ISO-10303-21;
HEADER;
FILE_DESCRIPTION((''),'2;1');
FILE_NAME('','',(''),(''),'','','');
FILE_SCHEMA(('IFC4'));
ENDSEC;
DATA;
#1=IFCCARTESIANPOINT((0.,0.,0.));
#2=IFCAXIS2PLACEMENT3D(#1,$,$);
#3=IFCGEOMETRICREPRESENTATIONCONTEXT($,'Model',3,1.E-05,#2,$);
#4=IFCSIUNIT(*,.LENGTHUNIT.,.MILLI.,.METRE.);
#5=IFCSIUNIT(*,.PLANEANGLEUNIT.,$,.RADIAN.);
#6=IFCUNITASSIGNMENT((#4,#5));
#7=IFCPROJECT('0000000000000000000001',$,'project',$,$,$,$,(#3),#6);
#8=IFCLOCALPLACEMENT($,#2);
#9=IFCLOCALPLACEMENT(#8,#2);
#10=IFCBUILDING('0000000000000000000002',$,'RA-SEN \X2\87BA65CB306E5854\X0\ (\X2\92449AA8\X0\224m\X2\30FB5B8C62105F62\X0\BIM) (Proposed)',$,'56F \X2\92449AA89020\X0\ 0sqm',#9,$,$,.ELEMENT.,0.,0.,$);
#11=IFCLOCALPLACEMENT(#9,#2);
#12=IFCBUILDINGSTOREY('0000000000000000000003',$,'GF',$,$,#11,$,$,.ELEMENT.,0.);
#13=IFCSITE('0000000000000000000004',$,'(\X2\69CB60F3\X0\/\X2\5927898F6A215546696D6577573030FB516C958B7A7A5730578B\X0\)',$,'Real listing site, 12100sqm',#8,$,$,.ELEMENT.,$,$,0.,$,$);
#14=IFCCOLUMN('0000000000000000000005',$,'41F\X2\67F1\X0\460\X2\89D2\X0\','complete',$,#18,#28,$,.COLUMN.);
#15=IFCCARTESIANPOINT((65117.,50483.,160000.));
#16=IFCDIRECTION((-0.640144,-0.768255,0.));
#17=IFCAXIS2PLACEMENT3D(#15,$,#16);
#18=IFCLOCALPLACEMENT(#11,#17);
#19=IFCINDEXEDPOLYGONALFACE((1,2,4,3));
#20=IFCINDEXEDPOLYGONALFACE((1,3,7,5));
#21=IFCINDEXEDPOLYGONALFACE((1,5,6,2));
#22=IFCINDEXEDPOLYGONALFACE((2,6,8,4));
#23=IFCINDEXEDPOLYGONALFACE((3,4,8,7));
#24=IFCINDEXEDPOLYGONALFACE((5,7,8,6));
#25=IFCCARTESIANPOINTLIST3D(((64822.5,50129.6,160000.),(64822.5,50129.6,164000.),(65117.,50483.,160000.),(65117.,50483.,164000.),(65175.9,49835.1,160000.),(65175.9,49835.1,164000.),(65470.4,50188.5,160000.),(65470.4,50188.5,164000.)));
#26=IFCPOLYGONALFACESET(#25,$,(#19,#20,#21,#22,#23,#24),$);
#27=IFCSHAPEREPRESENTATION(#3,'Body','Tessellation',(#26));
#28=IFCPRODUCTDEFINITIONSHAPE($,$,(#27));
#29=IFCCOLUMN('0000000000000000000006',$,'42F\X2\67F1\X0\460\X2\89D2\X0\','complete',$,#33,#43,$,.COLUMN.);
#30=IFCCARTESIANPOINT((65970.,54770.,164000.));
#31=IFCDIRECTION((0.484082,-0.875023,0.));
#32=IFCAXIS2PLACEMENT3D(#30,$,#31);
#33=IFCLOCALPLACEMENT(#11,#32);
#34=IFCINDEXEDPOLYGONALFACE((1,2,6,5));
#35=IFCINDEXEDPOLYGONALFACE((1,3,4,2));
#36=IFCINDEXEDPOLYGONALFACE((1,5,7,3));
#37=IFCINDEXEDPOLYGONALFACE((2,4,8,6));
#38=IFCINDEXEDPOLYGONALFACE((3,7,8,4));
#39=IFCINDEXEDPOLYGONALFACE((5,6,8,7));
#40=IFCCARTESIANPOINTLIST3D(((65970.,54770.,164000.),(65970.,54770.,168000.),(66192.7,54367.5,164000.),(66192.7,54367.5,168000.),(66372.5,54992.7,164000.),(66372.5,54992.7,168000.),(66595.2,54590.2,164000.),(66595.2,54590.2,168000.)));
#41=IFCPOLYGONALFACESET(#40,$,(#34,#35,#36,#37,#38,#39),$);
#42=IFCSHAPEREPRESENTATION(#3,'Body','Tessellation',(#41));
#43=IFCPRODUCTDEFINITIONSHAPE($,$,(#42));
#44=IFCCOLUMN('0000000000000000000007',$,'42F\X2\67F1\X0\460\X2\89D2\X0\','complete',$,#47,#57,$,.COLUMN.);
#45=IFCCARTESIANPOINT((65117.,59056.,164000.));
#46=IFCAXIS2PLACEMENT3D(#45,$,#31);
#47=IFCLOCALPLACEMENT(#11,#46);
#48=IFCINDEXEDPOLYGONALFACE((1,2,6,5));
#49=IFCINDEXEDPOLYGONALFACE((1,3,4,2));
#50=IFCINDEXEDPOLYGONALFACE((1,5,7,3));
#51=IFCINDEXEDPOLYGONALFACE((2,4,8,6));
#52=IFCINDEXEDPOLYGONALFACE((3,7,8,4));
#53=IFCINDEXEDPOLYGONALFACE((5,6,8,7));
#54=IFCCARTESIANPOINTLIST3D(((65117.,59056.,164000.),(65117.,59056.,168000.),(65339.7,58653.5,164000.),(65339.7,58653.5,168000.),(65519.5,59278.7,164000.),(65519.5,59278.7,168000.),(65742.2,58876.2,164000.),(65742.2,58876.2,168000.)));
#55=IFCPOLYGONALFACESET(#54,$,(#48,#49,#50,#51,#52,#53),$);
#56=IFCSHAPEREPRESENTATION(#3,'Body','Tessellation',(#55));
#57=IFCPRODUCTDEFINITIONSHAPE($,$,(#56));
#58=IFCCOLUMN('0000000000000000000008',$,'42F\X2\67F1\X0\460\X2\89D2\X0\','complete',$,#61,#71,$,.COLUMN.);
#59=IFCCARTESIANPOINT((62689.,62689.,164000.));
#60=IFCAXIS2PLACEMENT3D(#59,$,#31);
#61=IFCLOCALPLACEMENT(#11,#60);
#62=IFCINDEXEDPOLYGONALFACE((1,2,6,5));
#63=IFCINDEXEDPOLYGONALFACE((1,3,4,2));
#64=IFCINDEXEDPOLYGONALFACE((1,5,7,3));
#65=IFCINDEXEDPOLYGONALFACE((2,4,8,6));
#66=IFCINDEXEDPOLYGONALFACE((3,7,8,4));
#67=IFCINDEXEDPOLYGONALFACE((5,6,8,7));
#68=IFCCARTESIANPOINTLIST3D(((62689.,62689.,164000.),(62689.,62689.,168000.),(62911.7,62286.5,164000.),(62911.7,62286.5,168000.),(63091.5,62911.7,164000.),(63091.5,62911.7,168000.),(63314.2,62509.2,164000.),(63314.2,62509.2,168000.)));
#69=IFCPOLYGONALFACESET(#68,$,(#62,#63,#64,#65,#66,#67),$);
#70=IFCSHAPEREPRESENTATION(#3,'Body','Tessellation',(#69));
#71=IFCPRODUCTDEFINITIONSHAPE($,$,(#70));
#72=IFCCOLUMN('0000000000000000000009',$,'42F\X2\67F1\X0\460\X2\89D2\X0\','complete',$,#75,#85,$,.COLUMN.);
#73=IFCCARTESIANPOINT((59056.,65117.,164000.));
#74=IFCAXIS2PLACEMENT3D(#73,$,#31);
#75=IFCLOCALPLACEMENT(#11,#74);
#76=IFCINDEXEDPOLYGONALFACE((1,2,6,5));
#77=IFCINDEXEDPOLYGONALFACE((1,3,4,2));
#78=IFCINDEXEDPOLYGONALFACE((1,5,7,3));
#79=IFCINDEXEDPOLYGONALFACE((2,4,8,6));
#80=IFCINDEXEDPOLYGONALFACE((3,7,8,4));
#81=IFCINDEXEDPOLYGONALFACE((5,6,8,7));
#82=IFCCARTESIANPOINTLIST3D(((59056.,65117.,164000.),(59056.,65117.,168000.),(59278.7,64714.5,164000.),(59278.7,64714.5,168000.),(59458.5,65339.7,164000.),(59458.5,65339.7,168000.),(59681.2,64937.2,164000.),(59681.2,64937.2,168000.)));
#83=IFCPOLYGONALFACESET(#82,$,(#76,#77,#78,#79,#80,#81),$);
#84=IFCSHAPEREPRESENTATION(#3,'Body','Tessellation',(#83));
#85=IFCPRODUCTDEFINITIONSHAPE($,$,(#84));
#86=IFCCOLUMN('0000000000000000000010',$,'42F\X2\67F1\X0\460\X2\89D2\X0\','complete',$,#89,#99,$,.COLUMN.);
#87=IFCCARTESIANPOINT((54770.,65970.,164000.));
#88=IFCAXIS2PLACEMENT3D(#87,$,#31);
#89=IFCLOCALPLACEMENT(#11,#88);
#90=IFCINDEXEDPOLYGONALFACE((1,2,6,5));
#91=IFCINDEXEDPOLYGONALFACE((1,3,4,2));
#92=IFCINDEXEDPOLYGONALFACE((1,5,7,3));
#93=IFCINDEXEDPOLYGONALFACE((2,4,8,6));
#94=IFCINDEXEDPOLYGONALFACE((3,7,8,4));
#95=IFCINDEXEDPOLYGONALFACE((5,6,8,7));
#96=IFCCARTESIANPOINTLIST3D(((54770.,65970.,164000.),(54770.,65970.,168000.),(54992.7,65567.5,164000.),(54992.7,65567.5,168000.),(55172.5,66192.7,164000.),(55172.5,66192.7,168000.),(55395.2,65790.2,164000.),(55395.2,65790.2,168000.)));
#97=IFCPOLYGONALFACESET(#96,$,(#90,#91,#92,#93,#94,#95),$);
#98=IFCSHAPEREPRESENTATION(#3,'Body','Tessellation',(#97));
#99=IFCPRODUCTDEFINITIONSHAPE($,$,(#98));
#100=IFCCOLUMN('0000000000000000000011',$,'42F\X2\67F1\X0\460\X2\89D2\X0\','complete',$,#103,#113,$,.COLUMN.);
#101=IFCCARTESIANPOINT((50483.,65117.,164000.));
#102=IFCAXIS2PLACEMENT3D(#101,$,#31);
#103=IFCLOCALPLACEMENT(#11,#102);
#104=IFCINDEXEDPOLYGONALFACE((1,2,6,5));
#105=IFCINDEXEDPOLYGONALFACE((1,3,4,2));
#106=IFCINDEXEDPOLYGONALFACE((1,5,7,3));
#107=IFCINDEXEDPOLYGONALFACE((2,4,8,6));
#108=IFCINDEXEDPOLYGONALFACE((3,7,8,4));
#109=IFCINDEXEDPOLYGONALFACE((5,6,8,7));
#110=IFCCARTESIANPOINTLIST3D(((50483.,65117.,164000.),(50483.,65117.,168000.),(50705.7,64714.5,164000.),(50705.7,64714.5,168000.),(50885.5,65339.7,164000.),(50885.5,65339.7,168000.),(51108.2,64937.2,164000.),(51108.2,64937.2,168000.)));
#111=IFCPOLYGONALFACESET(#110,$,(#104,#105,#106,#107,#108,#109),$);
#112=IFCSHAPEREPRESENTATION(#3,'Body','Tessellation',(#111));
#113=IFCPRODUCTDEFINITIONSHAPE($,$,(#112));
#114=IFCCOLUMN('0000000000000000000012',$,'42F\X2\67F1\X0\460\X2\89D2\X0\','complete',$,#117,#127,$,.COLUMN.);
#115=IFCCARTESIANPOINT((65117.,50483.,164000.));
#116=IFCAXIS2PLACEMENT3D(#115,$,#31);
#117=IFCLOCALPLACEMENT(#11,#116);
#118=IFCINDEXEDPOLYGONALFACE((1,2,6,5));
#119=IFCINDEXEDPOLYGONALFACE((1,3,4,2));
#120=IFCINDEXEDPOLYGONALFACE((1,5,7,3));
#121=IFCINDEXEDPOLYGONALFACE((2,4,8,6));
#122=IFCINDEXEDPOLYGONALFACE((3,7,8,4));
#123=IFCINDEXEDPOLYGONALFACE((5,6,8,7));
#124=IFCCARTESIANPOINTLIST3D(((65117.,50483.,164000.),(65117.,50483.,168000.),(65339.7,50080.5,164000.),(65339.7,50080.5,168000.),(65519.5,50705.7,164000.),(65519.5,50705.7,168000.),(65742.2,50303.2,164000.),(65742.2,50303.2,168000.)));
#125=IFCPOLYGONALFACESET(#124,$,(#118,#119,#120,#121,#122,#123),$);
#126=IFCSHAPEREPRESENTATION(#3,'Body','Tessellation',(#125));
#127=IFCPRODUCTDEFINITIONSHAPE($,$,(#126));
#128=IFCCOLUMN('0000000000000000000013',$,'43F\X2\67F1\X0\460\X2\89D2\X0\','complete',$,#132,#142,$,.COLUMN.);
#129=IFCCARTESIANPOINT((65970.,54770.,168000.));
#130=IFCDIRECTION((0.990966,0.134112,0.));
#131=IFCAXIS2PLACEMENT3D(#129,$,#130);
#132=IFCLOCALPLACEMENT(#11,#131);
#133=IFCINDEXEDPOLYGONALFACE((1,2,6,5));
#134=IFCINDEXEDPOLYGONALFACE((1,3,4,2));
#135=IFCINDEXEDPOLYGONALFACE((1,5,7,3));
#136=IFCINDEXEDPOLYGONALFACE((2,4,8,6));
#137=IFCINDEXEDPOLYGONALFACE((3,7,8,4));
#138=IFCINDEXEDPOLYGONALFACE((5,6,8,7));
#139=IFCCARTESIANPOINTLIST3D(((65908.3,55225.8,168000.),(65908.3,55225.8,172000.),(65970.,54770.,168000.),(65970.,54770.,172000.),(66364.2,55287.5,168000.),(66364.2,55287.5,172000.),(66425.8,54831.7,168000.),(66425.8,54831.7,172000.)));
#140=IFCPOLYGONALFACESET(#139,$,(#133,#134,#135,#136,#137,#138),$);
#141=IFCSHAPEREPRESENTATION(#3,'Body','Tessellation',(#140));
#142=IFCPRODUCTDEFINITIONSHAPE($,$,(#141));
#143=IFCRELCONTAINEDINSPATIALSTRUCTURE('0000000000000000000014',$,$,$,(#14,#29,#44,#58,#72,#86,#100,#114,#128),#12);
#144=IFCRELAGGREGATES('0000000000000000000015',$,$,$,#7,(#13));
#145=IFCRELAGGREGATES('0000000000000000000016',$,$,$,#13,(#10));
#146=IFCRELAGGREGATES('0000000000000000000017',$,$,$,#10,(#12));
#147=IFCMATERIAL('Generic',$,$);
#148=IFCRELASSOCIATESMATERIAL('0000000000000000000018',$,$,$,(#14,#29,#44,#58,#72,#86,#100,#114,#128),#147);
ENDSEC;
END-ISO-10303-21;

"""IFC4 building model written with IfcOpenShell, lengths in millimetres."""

from ifc_helpers import new_model, si_unit, frame, frame_2d, origin, place, context, project, spatial, rectangle, extrude, material, element, save


model = new_model("IFC4")

# Units and contexts
model_context = context("Model", 3, precision=1e-05, world=origin())
ifc_project = project(units=[si_unit("LENGTHUNIT", "METRE", prefix="MILLI"), si_unit("PLANEANGLEUNIT", "RADIAN")], contexts=[model_context])

# Site, building, storey
site_placement = place(None, origin())
site = spatial("IfcSite", under=ifc_project, at=site_placement, Name="(構想/大規模商業敷地・公開空地型)", ObjectType="Real listing site, 12100sqm", CompositionType="ELEMENT", RefElevation=0.0)
building_placement = place(site_placement, origin())
building = spatial("IfcBuilding", under=site, at=building_placement, Name="RA-SEN 螺旋の塔 (鉄骨224m・完成形BIM) (Proposed)", ObjectType="56F 鉄骨造 0sqm", CompositionType="ELEMENT", ElevationOfRefHeight=0.0, ElevationOfTerrain=0.0)
storey_placement = place(building_placement, origin())
storey = spatial("IfcBuildingStorey", under=building, at=storey_placement, Name="GF", CompositionType="ELEMENT", Elevation=0.0)

# Columns
ifc_material = material(Name="Generic")
column_1_placement = place(storey_placement, frame((65117.0, 50483.0, 160000.0), x_axis=(-0.640144, -0.768255, 0.0)))
element("IfcColumn", 1, at=column_1_placement, inside=storey, material=ifc_material, Name="41F柱460角", Description="complete", PredefinedType="COLUMN", context=model_context, shape_type="SweptSolid", body=[
    extrude(rectangle(XDim=460.0, YDim=460.0, at=frame_2d((230.0, 230.0))), frame((65117.0, 50483.0, 160000.0), x_axis=(-0.640144, -0.768255, 0.0)), (0.0, 0.0, 1.0), 4000.0),
])
column_2_placement = place(storey_placement, frame((65970.0, 54770.0, 164000.0), x_axis=(0.484082, -0.875023, 0.0)))
element("IfcColumn", 2, at=column_2_placement, inside=storey, material=ifc_material, Name="42F柱460角", Description="complete", PredefinedType="COLUMN", context=model_context, shape_type="SweptSolid", body=[
    extrude(rectangle(XDim=460.0, YDim=460.0, at=frame_2d((230.0, 230.0))), frame((65970.0, 54770.0, 164000.0), x_axis=(0.484082, -0.875023, 0.0)), (0.0, 0.0, 1.0), 4000.0),
])
column_3_placement = place(storey_placement, frame((65117.0, 59056.0, 164000.0), x_axis=(0.484082, -0.875023, 0.0)))
element("IfcColumn", 3, at=column_3_placement, inside=storey, material=ifc_material, Name="42F柱460角", Description="complete", PredefinedType="COLUMN", context=model_context, shape_type="SweptSolid", body=[
    extrude(rectangle(XDim=460.0, YDim=460.0, at=frame_2d((230.0, 230.0))), frame((65117.0, 59056.0, 164000.0), x_axis=(0.484082, -0.875023, 0.0)), (0.0, 0.0, 1.0), 4000.0),
])
column_4_placement = place(storey_placement, frame((62689.0, 62689.0, 164000.0), x_axis=(0.484082, -0.875023, 0.0)))
element("IfcColumn", 4, at=column_4_placement, inside=storey, material=ifc_material, Name="42F柱460角", Description="complete", PredefinedType="COLUMN", context=model_context, shape_type="SweptSolid", body=[
    extrude(rectangle(XDim=460.0, YDim=460.0, at=frame_2d((230.0, 230.0))), frame((62689.0, 62689.0, 164000.0), x_axis=(0.484082, -0.875023, 0.0)), (0.0, 0.0, 1.0), 4000.0),
])
column_5_placement = place(storey_placement, frame((59056.0, 65117.0, 164000.0), x_axis=(0.484082, -0.875023, 0.0)))
element("IfcColumn", 5, at=column_5_placement, inside=storey, material=ifc_material, Name="42F柱460角", Description="complete", PredefinedType="COLUMN", context=model_context, shape_type="SweptSolid", body=[
    extrude(rectangle(XDim=460.0, YDim=460.0, at=frame_2d((230.0, 230.0))), frame((59056.0, 65117.0, 164000.0), x_axis=(0.484082, -0.875023, 0.0)), (0.0, 0.0, 1.0), 4000.0),
])
column_6_placement = place(storey_placement, frame((54770.0, 65970.0, 164000.0), x_axis=(0.484082, -0.875023, 0.0)))
element("IfcColumn", 6, at=column_6_placement, inside=storey, material=ifc_material, Name="42F柱460角", Description="complete", PredefinedType="COLUMN", context=model_context, shape_type="SweptSolid", body=[
    extrude(rectangle(XDim=460.0, YDim=460.0, at=frame_2d((230.0, 230.0))), frame((54770.0, 65970.0, 164000.0), x_axis=(0.484082, -0.875023, 0.0)), (0.0, 0.0, 1.0), 4000.0),
])
column_7_placement = place(storey_placement, frame((50483.0, 65117.0, 164000.0), x_axis=(0.484082, -0.875023, 0.0)))
element("IfcColumn", 7, at=column_7_placement, inside=storey, material=ifc_material, Name="42F柱460角", Description="complete", PredefinedType="COLUMN", context=model_context, shape_type="SweptSolid", body=[
    extrude(rectangle(XDim=460.0, YDim=460.0, at=frame_2d((230.0, 230.0))), frame((50483.0, 65117.0, 164000.0), x_axis=(0.484082, -0.875023, 0.0)), (0.0, 0.0, 1.0), 4000.0),
])
column_8_placement = place(storey_placement, frame((65117.0, 50483.0, 164000.0), x_axis=(0.484082, -0.875023, 0.0)))
element("IfcColumn", 8, at=column_8_placement, inside=storey, material=ifc_material, Name="42F柱460角", Description="complete", PredefinedType="COLUMN", context=model_context, shape_type="SweptSolid", body=[
    extrude(rectangle(XDim=460.0, YDim=460.0, at=frame_2d((230.0, 230.0))), frame((65117.0, 50483.0, 164000.0), x_axis=(0.484082, -0.875023, 0.0)), (0.0, 0.0, 1.0), 4000.0),
])
column_9_placement = place(storey_placement, frame((65970.0, 54770.0, 168000.0), x_axis=(0.990966, 0.134112, 0.0)))
element("IfcColumn", 9, at=column_9_placement, inside=storey, material=ifc_material, Name="43F柱460角", Description="complete", PredefinedType="COLUMN", context=model_context, shape_type="SweptSolid", body=[
    extrude(rectangle(XDim=460.0, YDim=460.0, at=frame_2d((230.0, 230.0))), frame((65970.0, 54770.0, 168000.0), x_axis=(0.990966, 0.134112, 0.0)), (0.0, 0.0, 1.0), 4000.0),
])

save(model, "model.ifc")
